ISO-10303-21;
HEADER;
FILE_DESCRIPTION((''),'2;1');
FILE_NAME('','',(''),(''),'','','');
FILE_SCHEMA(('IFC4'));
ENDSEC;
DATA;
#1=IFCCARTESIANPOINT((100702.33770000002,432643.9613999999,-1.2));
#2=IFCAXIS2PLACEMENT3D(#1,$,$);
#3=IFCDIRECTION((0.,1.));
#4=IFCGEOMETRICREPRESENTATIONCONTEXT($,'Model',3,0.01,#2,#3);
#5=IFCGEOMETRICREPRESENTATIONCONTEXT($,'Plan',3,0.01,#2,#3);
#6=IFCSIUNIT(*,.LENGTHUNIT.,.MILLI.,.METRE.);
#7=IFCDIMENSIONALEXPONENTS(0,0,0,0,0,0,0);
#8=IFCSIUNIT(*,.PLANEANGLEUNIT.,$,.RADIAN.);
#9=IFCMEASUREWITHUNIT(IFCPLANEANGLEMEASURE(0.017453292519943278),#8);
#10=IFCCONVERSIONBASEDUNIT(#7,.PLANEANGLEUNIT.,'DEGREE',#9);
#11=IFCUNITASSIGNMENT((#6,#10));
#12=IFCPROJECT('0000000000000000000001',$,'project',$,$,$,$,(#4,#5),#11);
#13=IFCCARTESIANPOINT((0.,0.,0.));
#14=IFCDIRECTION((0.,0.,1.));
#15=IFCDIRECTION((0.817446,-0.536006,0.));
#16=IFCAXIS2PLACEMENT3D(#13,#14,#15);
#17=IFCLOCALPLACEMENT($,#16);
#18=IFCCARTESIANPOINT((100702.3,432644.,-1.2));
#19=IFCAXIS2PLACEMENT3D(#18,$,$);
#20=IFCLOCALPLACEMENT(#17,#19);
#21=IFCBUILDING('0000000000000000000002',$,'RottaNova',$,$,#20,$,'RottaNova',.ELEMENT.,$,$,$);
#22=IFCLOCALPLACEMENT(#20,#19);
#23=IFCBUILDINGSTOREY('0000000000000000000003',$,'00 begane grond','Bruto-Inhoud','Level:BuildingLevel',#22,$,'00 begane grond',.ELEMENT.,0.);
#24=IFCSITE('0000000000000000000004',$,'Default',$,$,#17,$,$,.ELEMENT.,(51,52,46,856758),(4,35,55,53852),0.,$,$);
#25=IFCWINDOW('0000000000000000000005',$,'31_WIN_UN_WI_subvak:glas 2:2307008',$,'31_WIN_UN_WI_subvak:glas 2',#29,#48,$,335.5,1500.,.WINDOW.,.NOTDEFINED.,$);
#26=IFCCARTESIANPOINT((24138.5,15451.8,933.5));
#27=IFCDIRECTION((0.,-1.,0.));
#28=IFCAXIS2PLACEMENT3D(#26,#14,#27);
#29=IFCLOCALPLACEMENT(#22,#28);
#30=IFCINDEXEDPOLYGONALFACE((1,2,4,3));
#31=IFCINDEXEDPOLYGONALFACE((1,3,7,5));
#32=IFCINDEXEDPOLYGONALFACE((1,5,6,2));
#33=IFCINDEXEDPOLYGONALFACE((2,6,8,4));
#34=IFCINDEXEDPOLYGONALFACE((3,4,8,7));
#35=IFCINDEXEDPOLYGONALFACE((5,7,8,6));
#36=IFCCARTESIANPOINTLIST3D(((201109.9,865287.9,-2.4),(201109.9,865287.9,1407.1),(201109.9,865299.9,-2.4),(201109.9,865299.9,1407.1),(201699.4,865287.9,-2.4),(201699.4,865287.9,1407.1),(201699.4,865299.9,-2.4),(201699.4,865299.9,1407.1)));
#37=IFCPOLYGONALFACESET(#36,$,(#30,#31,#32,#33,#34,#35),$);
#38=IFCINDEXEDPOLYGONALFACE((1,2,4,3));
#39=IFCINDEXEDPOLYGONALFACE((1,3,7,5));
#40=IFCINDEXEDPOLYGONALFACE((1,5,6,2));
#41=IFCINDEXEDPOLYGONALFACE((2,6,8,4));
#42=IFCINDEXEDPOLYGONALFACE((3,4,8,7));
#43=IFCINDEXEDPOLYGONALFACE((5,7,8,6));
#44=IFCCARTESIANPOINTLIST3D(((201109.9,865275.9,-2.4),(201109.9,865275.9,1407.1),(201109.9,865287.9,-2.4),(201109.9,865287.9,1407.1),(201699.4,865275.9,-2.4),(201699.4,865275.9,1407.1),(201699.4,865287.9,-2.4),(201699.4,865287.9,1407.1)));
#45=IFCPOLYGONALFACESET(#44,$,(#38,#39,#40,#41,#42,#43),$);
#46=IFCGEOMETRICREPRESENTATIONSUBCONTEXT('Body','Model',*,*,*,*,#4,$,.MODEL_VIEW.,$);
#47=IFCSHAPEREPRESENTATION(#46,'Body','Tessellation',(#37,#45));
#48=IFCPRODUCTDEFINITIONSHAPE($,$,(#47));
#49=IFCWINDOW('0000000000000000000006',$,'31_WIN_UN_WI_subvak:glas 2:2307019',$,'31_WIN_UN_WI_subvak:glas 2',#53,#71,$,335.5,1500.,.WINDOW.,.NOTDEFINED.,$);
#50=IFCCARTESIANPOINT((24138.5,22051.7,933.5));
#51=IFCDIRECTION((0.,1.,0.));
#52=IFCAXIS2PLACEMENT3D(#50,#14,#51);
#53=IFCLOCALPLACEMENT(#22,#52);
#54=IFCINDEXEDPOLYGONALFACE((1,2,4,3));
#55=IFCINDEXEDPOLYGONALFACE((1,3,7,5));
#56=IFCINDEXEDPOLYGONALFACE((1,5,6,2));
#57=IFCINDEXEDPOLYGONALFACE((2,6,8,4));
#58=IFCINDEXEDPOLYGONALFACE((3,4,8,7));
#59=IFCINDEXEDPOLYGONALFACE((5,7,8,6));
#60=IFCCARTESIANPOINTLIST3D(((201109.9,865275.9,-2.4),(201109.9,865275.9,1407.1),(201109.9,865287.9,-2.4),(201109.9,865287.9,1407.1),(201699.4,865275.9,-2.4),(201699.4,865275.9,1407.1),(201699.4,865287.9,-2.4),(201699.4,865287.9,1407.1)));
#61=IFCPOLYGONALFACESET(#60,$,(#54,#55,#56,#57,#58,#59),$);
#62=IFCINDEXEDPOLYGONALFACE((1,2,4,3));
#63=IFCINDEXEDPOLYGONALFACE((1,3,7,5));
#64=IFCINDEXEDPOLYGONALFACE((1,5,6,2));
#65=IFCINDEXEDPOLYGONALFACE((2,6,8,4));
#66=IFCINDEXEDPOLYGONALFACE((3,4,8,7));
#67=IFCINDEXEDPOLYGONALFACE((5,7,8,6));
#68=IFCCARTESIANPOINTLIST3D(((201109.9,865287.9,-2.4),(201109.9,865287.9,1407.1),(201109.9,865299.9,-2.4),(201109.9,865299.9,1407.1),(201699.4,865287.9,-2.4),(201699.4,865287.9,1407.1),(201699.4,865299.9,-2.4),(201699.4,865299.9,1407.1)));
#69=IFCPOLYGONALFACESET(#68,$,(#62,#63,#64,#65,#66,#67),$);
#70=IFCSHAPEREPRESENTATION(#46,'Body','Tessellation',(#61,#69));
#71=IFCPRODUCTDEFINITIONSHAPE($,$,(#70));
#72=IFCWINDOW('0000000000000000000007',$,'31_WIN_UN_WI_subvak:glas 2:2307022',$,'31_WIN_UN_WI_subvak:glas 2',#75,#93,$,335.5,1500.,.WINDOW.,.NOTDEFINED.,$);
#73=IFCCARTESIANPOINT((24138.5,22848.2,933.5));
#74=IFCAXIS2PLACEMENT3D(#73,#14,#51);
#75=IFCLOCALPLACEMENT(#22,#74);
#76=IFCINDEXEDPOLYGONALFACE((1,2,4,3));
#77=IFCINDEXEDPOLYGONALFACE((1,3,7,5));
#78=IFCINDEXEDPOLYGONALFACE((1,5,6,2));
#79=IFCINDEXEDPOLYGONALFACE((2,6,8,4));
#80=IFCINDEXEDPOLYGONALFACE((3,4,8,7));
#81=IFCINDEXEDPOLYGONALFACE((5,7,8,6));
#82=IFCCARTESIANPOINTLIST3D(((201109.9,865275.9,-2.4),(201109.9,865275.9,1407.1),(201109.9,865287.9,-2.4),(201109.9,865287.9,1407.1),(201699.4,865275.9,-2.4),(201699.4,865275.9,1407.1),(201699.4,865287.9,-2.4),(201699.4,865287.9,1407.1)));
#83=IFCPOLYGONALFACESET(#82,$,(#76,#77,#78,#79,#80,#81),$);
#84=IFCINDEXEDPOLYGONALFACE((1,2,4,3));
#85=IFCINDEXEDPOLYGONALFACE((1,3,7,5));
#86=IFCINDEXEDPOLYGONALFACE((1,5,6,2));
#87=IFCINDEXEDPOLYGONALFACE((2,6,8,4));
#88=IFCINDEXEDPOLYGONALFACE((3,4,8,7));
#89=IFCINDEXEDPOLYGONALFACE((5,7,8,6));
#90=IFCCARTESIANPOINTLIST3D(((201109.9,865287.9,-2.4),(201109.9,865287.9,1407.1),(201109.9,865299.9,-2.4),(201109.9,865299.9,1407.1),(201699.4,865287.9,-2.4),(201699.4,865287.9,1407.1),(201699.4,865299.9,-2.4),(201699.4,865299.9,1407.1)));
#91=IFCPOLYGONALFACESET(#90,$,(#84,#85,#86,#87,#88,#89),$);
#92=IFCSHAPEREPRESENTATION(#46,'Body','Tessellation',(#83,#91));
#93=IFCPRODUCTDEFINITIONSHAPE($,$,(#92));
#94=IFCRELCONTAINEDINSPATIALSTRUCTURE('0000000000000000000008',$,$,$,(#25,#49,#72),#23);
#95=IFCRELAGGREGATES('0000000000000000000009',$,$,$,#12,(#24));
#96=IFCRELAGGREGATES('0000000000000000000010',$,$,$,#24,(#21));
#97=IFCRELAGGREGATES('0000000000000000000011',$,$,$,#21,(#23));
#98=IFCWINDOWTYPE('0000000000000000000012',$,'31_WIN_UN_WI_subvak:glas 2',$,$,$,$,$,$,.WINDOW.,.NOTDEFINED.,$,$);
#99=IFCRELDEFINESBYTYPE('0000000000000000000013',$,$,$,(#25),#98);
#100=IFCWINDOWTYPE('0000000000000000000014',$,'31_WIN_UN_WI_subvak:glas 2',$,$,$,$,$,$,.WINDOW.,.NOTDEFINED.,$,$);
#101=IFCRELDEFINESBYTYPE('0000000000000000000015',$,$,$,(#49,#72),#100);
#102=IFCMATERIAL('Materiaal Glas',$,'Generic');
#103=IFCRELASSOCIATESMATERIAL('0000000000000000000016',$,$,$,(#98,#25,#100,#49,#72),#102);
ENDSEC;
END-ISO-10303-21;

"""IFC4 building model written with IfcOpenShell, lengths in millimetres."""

from ifc_helpers import new_model, entity, si_unit, converted_unit, direction, frame, place, context, subcontext, project, spatial, indexed_curve, outline, extrude, source, transform, mapped, material, type_object, type_shapes, element, save


model = new_model("IFC4")

# Units and contexts
model_context = context("Model", 3, precision=0.01, world=frame((100702.33770000002, 432643.9613999999, -1.2)), true_north=direction((0.0, 1.0)))
plan_context = context("Plan", 3, precision=0.01, world=frame((100702.33770000002, 432643.9613999999, -1.2)), true_north=direction((0.0, 1.0)))
body_context = subcontext(model_context, "Body", "Model", "MODEL_VIEW")
ifc_project = project(units=[si_unit("LENGTHUNIT", "METRE", prefix="MILLI"), converted_unit("PLANEANGLEUNIT", "DEGREE", entity("IfcPlaneAngleMeasure", 0.017453292519943278), si_unit("PLANEANGLEUNIT", "RADIAN"), dimensions=[0, 0, 0, 0, 0, 0, 0])], contexts=[model_context, plan_context])

# Site, building, storey
site_placement = place(None, frame((0.0, 0.0, 0.0), z_axis=(0.0, 0.0, 1.0), x_axis=(0.817446, -0.536006, 0.0)))
site = spatial("IfcSite", under=ifc_project, at=site_placement, Name="Default", CompositionType="ELEMENT", RefLatitude=(51, 52, 46, 856758), RefLongitude=(4, 35, 55, 53852), RefElevation=0.0)
building_placement = place(site_placement, frame((100702.3, 432644.0, -1.2)))
building = spatial("IfcBuilding", under=site, at=building_placement, Name="RottaNova", LongName="RottaNova", CompositionType="ELEMENT")
storey_placement = place(building_placement, frame((100702.3, 432644.0, -1.2)))
storey = spatial("IfcBuildingStorey", under=building, at=storey_placement, Name="00 begane grond", Description="Bruto-Inhoud", ObjectType="Level:BuildingLevel", LongName="00 begane grond", CompositionType="ELEMENT", Elevation=0.0)

# Windows
ifc_material_1 = material(Name="Materiaal Glas", Category="Generic")
window_type_1 = type_object("IfcWindowType", Name="31_WIN_UN_WI_subvak:glas 2", PartitioningType="NOTDEFINED", PredefinedType="WINDOW", material=ifc_material_1)
shared_shape_1 = source(frame((100702.3, 432644.0, -1.2)), body_context, "Body", "SweptSolid", [
    extrude(outline(indexed_curve([(-6.0, -294.7), (6.0, -294.7), (6.0, 294.7), (-6.0, 294.7), (-6.0, -294.7)], self_intersect=False)), frame((0.0, 6.0, 0.0), z_axis=(0.0, 0.0, 1.0), x_axis=(0.0, -1.0, 0.0)), (0.0, 0.0, 1.0), 1409.5),
    extrude(outline(indexed_curve([(-6.0, -294.8), (6.0, -294.8), (6.0, 294.8), (-6.0, 294.8), (-6.0, -294.8)], self_intersect=False)), frame((0.0, -6.0, 0.0), z_axis=(0.0, 0.0, 1.0), x_axis=(0.0, -1.0, 0.0)), (0.0, 0.0, 1.0), 1409.5),
])
type_shapes(window_type_1, [shared_shape_1])
for number, where, z_axis, x_axis, name in (
    (1, (24138.5, 15451.8, 933.5), (0.0, 0.0, 1.0), (0.0, -1.0, 0.0), "31_WIN_UN_WI_subvak:glas 2:2307008"),
):
    element("IfcWindow", number, at=place(storey_placement, frame(where, z_axis=z_axis, x_axis=x_axis)), inside=storey, type_object=window_type_1, material=ifc_material_1, Name=name, ObjectType="31_WIN_UN_WI_subvak:glas 2", OverallHeight=335.5, OverallWidth=1500.0, PartitioningType="NOTDEFINED", PredefinedType="WINDOW", context=body_context, shape_type="MappedRepresentation", body=[
        mapped(shared_shape_1, transform((100702.3, 432644.0, -1.2), scale=1.0)),
    ])
window_type_2 = type_object("IfcWindowType", Name="31_WIN_UN_WI_subvak:glas 2", PartitioningType="NOTDEFINED", PredefinedType="WINDOW", material=ifc_material_1)
shared_shape_2 = source(frame((100702.3, 432644.0, -1.2)), body_context, "Body", "SweptSolid", [
    extrude(outline(indexed_curve([(-294.7, -6.0), (294.7, -6.0), (294.7, 6.0), (-294.7, 6.0), (-294.7, -6.0)], self_intersect=False)), frame((0.0, -6.0, 0.0)), (0.0, 0.0, 1.0), 1409.5),
    extrude(outline(indexed_curve([(-294.8, -6.0), (294.8, -6.0), (294.8, 6.0), (-294.8, 6.0), (-294.8, -6.0)], self_intersect=False)), frame((0.0, 6.0, 0.0)), (0.0, 0.0, 1.0), 1409.5),
])
type_shapes(window_type_2, [shared_shape_2])
for number, where, z_axis, x_axis, name in (
    (2, (24138.5, 22051.7, 933.5), (0.0, 0.0, 1.0), (0.0, 1.0, 0.0), "31_WIN_UN_WI_subvak:glas 2:2307019"),
    (3, (24138.5, 22848.2, 933.5), (0.0, 0.0, 1.0), (0.0, 1.0, 0.0), "31_WIN_UN_WI_subvak:glas 2:2307022"),
):
    element("IfcWindow", number, at=place(storey_placement, frame(where, z_axis=z_axis, x_axis=x_axis)), inside=storey, type_object=window_type_2, material=ifc_material_1, Name=name, ObjectType="31_WIN_UN_WI_subvak:glas 2", OverallHeight=335.5, OverallWidth=1500.0, PartitioningType="NOTDEFINED", PredefinedType="WINDOW", context=body_context, shape_type="MappedRepresentation", body=[
        mapped(shared_shape_2, transform((100702.3, 432644.0, -1.2), scale=1.0)),
    ])

save(model, "model.ifc")
